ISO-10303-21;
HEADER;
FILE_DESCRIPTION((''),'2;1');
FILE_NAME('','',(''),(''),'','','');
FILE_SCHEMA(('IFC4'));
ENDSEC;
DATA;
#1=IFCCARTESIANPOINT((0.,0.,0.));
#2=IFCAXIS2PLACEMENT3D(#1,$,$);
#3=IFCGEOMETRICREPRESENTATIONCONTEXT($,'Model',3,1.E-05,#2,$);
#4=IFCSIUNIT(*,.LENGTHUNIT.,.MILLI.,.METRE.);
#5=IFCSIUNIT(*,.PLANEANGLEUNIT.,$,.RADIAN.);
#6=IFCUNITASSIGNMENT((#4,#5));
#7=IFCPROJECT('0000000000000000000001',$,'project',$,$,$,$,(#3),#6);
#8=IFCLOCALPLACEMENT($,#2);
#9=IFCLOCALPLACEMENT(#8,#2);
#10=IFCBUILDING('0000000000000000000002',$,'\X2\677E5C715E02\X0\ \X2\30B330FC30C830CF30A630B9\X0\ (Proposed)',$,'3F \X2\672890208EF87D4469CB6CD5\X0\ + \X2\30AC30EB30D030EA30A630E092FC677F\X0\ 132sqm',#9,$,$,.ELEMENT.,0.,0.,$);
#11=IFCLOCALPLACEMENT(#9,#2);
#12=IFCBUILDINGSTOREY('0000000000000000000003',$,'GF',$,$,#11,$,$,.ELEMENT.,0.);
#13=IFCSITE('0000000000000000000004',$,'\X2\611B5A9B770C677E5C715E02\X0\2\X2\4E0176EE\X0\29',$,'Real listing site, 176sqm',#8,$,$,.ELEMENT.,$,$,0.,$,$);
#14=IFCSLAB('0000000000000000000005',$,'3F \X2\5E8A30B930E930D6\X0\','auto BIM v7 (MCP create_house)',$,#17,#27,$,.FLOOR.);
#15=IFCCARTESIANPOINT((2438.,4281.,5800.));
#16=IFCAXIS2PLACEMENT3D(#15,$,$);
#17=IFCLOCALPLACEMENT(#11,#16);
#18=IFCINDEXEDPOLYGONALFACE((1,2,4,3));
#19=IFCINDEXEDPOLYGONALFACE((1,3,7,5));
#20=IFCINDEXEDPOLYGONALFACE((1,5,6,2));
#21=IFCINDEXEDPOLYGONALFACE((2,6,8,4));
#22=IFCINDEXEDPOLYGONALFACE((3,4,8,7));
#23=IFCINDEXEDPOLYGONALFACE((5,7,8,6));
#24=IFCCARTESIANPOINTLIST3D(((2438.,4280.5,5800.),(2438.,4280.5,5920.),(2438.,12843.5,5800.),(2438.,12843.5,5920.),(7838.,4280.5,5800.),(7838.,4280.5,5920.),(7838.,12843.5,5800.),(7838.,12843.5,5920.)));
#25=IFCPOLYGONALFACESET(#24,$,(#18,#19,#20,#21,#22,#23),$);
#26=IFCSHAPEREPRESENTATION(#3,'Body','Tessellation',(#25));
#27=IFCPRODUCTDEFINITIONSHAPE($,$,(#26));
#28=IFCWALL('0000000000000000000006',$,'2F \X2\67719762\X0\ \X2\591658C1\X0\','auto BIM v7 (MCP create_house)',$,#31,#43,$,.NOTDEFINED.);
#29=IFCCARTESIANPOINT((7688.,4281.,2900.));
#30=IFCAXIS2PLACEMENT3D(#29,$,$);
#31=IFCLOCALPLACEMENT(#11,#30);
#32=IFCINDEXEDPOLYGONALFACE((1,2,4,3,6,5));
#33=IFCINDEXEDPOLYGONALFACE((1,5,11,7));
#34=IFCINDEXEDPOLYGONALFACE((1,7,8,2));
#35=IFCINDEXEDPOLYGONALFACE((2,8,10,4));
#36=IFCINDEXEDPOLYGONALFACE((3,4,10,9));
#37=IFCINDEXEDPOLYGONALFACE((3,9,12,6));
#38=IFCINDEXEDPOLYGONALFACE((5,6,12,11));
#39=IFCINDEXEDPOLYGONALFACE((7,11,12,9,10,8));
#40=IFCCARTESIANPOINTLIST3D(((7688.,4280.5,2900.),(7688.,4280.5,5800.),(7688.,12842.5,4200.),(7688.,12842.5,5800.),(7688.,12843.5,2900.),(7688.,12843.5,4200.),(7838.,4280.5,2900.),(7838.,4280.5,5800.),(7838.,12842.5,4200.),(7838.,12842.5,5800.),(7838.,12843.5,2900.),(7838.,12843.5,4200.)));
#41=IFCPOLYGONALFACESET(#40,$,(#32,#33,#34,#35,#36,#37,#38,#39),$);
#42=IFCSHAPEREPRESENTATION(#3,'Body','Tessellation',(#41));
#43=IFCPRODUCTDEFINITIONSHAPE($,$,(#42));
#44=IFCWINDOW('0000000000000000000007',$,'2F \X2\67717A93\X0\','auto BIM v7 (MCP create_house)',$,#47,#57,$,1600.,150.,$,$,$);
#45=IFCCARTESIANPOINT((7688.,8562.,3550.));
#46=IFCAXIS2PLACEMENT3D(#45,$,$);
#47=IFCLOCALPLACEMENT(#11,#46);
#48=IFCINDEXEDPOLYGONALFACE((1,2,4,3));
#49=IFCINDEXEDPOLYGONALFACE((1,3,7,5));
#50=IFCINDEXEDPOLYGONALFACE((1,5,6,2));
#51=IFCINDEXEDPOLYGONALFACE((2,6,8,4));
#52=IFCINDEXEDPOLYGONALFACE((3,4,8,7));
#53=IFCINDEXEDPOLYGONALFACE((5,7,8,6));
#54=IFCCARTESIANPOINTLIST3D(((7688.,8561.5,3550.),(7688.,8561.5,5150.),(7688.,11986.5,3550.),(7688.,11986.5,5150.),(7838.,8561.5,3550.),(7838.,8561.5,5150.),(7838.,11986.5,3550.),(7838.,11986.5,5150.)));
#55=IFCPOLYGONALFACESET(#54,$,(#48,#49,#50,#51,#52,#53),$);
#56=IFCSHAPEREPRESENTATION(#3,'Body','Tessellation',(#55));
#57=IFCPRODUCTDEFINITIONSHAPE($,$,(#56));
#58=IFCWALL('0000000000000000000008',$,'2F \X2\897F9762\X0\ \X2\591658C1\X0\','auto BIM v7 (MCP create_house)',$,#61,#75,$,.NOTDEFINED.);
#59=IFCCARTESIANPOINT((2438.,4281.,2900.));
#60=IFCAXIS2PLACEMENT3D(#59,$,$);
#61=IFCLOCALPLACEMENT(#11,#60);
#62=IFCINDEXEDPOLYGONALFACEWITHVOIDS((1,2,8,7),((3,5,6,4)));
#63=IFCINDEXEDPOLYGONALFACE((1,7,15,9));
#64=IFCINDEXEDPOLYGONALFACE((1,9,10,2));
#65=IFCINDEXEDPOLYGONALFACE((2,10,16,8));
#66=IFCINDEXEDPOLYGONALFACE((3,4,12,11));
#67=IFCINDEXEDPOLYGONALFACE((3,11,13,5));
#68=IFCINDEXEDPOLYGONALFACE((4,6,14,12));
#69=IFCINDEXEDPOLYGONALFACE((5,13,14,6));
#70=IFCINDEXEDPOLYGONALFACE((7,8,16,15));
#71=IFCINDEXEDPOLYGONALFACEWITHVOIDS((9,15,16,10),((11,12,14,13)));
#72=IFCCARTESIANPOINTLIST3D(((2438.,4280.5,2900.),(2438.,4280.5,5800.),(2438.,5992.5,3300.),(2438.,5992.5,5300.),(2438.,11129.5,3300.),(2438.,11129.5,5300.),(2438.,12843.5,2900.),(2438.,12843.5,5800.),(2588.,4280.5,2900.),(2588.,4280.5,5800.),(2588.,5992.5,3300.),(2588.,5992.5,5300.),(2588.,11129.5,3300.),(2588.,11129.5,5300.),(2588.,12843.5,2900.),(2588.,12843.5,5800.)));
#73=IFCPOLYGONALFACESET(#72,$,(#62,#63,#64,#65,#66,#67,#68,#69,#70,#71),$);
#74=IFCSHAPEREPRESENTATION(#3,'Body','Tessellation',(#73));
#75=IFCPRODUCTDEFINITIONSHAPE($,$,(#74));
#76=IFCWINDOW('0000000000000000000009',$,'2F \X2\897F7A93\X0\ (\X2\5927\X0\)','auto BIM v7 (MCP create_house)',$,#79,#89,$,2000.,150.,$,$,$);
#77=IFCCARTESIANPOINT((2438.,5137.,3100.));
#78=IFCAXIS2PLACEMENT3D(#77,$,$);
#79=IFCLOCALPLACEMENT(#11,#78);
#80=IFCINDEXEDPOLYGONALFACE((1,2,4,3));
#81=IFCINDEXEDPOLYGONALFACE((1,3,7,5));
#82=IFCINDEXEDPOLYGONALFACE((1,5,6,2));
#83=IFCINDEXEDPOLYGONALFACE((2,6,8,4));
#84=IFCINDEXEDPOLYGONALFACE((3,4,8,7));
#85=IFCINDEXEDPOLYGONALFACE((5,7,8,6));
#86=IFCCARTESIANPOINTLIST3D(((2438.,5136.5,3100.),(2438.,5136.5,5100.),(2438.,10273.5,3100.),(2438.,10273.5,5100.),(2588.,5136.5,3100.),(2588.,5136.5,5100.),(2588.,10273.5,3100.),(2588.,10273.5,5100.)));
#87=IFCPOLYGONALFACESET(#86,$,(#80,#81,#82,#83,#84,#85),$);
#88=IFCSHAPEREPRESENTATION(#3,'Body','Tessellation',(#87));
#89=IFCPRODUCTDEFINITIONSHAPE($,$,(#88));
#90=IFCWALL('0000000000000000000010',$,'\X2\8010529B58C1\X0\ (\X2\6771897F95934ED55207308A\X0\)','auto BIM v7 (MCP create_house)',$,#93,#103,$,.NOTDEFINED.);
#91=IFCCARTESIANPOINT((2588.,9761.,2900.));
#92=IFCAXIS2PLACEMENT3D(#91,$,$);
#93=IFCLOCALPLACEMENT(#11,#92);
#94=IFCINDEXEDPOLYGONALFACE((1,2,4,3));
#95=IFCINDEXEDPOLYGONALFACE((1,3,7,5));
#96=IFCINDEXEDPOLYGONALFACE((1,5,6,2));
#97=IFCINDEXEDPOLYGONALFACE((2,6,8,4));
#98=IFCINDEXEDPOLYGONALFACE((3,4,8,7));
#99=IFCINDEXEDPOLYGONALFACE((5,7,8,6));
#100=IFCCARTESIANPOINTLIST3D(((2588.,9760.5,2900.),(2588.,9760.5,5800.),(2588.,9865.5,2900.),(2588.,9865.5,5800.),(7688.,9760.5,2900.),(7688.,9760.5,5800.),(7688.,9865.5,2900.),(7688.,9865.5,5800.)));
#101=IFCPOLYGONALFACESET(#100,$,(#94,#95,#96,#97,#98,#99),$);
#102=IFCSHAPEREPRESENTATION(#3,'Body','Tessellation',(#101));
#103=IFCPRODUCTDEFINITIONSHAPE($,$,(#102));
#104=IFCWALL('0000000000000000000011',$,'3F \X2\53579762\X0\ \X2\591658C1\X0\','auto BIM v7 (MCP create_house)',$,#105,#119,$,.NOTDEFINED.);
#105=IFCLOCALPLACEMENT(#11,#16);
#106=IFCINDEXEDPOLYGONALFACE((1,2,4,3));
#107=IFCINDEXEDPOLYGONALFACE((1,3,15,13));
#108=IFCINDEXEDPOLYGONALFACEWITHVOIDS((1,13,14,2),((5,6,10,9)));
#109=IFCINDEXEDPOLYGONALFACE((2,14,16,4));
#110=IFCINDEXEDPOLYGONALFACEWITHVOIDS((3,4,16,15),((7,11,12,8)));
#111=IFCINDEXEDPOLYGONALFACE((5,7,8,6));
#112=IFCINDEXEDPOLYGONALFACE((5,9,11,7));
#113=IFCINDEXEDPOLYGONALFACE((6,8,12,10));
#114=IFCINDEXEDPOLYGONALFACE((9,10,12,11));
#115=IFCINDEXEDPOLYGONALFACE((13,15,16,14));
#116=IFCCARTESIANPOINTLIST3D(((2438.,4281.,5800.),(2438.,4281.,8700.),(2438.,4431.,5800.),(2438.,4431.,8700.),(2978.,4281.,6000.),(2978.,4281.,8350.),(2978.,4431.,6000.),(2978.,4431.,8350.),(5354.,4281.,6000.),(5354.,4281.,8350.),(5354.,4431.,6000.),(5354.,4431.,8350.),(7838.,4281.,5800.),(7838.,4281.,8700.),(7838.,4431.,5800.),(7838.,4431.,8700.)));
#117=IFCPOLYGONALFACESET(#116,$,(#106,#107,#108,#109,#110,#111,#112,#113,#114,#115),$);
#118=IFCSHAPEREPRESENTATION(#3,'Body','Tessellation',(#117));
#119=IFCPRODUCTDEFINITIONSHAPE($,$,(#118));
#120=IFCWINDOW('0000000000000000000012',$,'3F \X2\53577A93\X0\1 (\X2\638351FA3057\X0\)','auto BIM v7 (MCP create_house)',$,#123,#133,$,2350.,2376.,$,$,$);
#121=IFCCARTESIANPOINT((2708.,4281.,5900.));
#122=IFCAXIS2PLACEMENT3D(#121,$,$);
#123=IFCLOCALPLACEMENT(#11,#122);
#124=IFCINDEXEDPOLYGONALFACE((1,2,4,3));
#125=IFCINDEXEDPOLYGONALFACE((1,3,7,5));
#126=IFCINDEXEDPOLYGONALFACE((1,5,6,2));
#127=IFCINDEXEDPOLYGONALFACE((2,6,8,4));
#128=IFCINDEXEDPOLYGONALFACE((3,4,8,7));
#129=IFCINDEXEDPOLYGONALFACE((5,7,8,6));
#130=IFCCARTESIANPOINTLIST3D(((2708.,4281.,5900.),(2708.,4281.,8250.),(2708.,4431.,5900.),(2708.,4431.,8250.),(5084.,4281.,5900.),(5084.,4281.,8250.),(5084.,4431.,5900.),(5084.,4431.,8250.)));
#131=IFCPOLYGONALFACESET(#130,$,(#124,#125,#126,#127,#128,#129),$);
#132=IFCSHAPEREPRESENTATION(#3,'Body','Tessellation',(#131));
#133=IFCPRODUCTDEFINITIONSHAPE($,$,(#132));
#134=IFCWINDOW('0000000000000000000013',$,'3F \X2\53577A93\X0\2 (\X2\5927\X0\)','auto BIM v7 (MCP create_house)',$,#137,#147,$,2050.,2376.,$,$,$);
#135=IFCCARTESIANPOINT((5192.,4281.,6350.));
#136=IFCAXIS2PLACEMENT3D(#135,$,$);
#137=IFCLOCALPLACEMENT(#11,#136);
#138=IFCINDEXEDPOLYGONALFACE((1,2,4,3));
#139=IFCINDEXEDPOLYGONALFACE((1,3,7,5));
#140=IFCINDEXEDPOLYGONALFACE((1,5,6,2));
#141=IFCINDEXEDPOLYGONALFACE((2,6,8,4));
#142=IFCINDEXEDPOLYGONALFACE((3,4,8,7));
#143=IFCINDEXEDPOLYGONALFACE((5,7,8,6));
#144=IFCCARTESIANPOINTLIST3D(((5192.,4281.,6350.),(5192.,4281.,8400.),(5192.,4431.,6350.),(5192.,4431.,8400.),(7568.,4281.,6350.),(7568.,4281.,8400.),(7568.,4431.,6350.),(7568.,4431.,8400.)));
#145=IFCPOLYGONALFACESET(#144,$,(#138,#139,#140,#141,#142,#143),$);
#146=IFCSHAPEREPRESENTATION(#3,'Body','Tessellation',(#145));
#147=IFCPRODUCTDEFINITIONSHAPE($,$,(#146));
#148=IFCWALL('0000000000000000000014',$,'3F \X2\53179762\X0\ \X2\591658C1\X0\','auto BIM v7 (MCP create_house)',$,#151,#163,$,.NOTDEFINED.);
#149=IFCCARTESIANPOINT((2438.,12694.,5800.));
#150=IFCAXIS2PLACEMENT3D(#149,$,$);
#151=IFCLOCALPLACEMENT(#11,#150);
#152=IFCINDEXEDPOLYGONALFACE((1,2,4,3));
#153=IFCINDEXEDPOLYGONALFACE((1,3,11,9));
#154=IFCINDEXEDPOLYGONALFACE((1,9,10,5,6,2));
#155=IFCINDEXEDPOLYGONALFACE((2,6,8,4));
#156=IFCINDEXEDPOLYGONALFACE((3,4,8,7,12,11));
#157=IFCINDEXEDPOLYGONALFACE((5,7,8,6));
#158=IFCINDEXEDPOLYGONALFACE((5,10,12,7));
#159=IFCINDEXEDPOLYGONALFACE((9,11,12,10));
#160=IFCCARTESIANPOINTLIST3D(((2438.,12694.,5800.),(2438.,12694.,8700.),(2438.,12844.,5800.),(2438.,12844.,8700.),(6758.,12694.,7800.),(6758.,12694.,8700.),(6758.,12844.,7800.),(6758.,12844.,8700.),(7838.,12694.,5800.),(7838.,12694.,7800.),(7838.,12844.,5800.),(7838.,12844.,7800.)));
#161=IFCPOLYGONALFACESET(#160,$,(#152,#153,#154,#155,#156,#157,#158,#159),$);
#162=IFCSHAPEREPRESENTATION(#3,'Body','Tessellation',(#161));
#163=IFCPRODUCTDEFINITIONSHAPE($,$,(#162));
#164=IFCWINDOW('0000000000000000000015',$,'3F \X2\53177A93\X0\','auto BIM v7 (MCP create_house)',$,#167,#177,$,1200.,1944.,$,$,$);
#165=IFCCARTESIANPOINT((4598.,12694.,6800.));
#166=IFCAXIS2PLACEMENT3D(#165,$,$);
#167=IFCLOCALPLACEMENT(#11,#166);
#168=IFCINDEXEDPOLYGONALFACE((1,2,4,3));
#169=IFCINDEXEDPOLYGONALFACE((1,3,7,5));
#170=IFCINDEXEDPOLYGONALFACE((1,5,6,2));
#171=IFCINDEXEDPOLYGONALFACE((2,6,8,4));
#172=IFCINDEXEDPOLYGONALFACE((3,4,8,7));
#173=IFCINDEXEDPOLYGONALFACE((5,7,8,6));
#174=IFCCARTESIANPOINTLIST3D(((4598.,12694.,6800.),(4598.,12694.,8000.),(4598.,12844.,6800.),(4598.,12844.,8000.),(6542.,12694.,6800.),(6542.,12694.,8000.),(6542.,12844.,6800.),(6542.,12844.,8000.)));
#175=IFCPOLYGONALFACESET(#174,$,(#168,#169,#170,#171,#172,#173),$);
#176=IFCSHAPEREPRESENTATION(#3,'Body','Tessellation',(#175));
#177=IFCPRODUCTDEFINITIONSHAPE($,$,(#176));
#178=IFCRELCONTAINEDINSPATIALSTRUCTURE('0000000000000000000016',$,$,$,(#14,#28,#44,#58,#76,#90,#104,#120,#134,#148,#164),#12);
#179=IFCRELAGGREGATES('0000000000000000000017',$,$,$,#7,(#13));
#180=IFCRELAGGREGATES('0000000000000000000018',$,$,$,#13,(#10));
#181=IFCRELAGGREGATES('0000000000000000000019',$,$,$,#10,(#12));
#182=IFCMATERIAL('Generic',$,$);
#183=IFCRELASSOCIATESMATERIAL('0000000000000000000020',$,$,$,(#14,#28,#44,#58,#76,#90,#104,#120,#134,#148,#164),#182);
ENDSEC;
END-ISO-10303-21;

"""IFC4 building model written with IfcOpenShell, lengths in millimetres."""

from ifc_helpers import new_model, si_unit, frame, frame_2d, origin, place, context, project, spatial, rectangle, extrude, material, element, fill, save


model = new_model("IFC4")

# Units and contexts
model_context = context("Model", 3, precision=1e-05, world=origin())
ifc_project = project(units=[si_unit("LENGTHUNIT", "METRE", prefix="MILLI"), si_unit("PLANEANGLEUNIT", "RADIAN")], contexts=[model_context])

# Site, building, storey
site_placement = place(None, origin())
site = spatial("IfcSite", under=ifc_project, at=site_placement, Name="愛媛県松山市2丁目29", ObjectType="Real listing site, 176sqm", CompositionType="ELEMENT", RefElevation=0.0)
building_placement = place(site_placement, origin())
building = spatial("IfcBuilding", under=site, at=building_placement, Name="松山市 コートハウス (Proposed)", ObjectType="3F 木造軸組構法 + ガルバリウム鋼板 132sqm", CompositionType="ELEMENT", ElevationOfRefHeight=0.0, ElevationOfTerrain=0.0)
storey_placement = place(building_placement, origin())
storey = spatial("IfcBuildingStorey", under=building, at=storey_placement, Name="GF", CompositionType="ELEMENT", Elevation=0.0)

# Slab
ifc_material = material(Name="Generic")
slab_placement = place(storey_placement, frame((2438.0, 4281.0, 5800.0)))
element("IfcSlab", 1, at=slab_placement, inside=storey, material=ifc_material, Name="3F 床スラブ", Description="auto BIM v7 (MCP create_house)", PredefinedType="FLOOR", context=model_context, shape_type="SweptSolid", body=[
    extrude(rectangle(XDim=5400.0, YDim=8563.0, at=frame_2d((2700.0, 4281.0))), frame((2438.0, 4281.0, 5800.0)), (0.0, 0.0, 1.0), 120.0),
])

# Walls, openings, windows
wall_1_placement = place(storey_placement, frame((7688.0, 4281.0, 2900.0)))
wall_1 = element("IfcWall", 2, at=wall_1_placement, inside=storey, material=ifc_material, Name="2F 東面 外壁", Description="auto BIM v7 (MCP create_house)", PredefinedType="NOTDEFINED", context=model_context, shape_type="SweptSolid", body=[
    extrude(rectangle(XDim=150.0, YDim=8563.0, at=frame_2d((75.0, 4281.0))), frame((7688.0, 4281.0, 2900.0)), (0.0, 0.0, 1.0), 2900.0),
])
opening_1_placement = place(storey_placement, frame((7688.0, 8562.0, 3550.0)))
opening_1 = element("IfcOpeningElement", 3, at=opening_1_placement, cuts=wall_1, PredefinedType="NOTDEFINED", context=model_context, shape_type="SweptSolid", body=[
    extrude(rectangle(XDim=150.0, YDim=3425.0, at=frame_2d((75.0, 1712.0))), frame((7688.0, 8562.0, 3550.0)), (0.0, 0.0, 1.0), 1600.0),
])
window_1_placement = place(storey_placement, frame((7688.0, 8562.0, 3550.0)))
window_1 = element("IfcWindow", 4, at=window_1_placement, inside=storey, material=ifc_material, Name="2F 東窓", Description="auto BIM v7 (MCP create_house)", OverallHeight=1600.0, OverallWidth=150.0, context=model_context, shape_type="SweptSolid", body=[
    extrude(rectangle(XDim=150.0, YDim=3425.0, at=frame_2d((75.0, 1712.0))), frame((7688.0, 8562.0, 3550.0)), (0.0, 0.0, 1.0), 1600.0),
])
fill(opening_1, window_1)
wall_2_placement = place(storey_placement, frame((2438.0, 4281.0, 2900.0)))
wall_2 = element("IfcWall", 5, at=wall_2_placement, inside=storey, material=ifc_material, Name="2F 西面 外壁", Description="auto BIM v7 (MCP create_house)", PredefinedType="NOTDEFINED", context=model_context, shape_type="SweptSolid", body=[
    extrude(rectangle(XDim=150.0, YDim=8563.0, at=frame_2d((75.0, 4281.0))), frame((2438.0, 4281.0, 2900.0)), (0.0, 0.0, 1.0), 2900.0),
])
opening_2_placement = place(storey_placement, frame((2438.0, 5137.0, 3100.0)))
opening_2 = element("IfcOpeningElement", 6, at=opening_2_placement, cuts=wall_2, PredefinedType="NOTDEFINED", context=model_context, shape_type="SweptSolid", body=[
    extrude(rectangle(XDim=150.0, YDim=5137.0, at=frame_2d((75.0, 2568.0))), frame((2438.0, 5137.0, 3100.0)), (0.0, 0.0, 1.0), 2000.0),
])
window_2_placement = place(storey_placement, frame((2438.0, 5137.0, 3100.0)))
window_2 = element("IfcWindow", 7, at=window_2_placement, inside=storey, material=ifc_material, Name="2F 西窓 (大)", Description="auto BIM v7 (MCP create_house)", OverallHeight=2000.0, OverallWidth=150.0, context=model_context, shape_type="SweptSolid", body=[
    extrude(rectangle(XDim=150.0, YDim=5137.0, at=frame_2d((75.0, 2568.0))), frame((2438.0, 5137.0, 3100.0)), (0.0, 0.0, 1.0), 2000.0),
])
fill(opening_2, window_2)

# Wall
wall_3_placement = place(storey_placement, frame((2588.0, 9761.0, 2900.0)))
element("IfcWall", 8, at=wall_3_placement, inside=storey, material=ifc_material, Name="耐力壁 (東西間仕切り)", Description="auto BIM v7 (MCP create_house)", PredefinedType="NOTDEFINED", context=model_context, shape_type="SweptSolid", body=[
    extrude(rectangle(XDim=5100.0, YDim=105.0, at=frame_2d((2550.0, 52.0))), frame((2588.0, 9761.0, 2900.0)), (0.0, 0.0, 1.0), 2900.0),
])

# Wall, openings, windows
wall_4_placement = place(storey_placement, frame((2438.0, 4281.0, 5800.0)))
wall_4 = element("IfcWall", 9, at=wall_4_placement, inside=storey, material=ifc_material, Name="3F 南面 外壁", Description="auto BIM v7 (MCP create_house)", PredefinedType="NOTDEFINED", context=model_context, shape_type="SweptSolid", body=[
    extrude(rectangle(XDim=5400.0, YDim=150.0, at=frame_2d((2700.0, 75.0))), frame((2438.0, 4281.0, 5800.0)), (0.0, 0.0, 1.0), 2900.0),
])
opening_3_placement = place(storey_placement, frame((2708.0, 4281.0, 5900.0)))
opening_3 = element("IfcOpeningElement", 10, at=opening_3_placement, cuts=wall_4, PredefinedType="NOTDEFINED", context=model_context, shape_type="SweptSolid", body=[
    extrude(rectangle(XDim=2376.0, YDim=150.0, at=frame_2d((1188.0, 75.0))), frame((2708.0, 4281.0, 5900.0)), (0.0, 0.0, 1.0), 2350.0),
])
opening_4_placement = place(storey_placement, frame((5192.0, 4281.0, 6350.0)))
opening_4 = element("IfcOpeningElement", 11, at=opening_4_placement, cuts=wall_4, PredefinedType="NOTDEFINED", context=model_context, shape_type="SweptSolid", body=[
    extrude(rectangle(XDim=2376.0, YDim=150.0, at=frame_2d((1188.0, 75.0))), frame((5192.0, 4281.0, 6350.0)), (0.0, 0.0, 1.0), 2050.0),
])
window_3_placement = place(storey_placement, frame((2708.0, 4281.0, 5900.0)))
window_3 = element("IfcWindow", 12, at=window_3_placement, inside=storey, material=ifc_material, Name="3F 南窓1 (掃出し)", Description="auto BIM v7 (MCP create_house)", OverallHeight=2350.0, OverallWidth=2376.0, context=model_context, shape_type="SweptSolid", body=[
    extrude(rectangle(XDim=2376.0, YDim=150.0, at=frame_2d((1188.0, 75.0))), frame((2708.0, 4281.0, 5900.0)), (0.0, 0.0, 1.0), 2350.0),
])
fill(opening_3, window_3)
window_4_placement = place(storey_placement, frame((5192.0, 4281.0, 6350.0)))
window_4 = element("IfcWindow", 13, at=window_4_placement, inside=storey, material=ifc_material, Name="3F 南窓2 (大)", Description="auto BIM v7 (MCP create_house)", OverallHeight=2050.0, OverallWidth=2376.0, context=model_context, shape_type="SweptSolid", body=[
    extrude(rectangle(XDim=2376.0, YDim=150.0, at=frame_2d((1188.0, 75.0))), frame((5192.0, 4281.0, 6350.0)), (0.0, 0.0, 1.0), 2050.0),
])
fill(opening_4, window_4)

# Wall, opening, window
wall_5_placement = place(storey_placement, frame((2438.0, 12694.0, 5800.0)))
wall_5 = element("IfcWall", 14, at=wall_5_placement, inside=storey, material=ifc_material, Name="3F 北面 外壁", Description="auto BIM v7 (MCP create_house)", PredefinedType="NOTDEFINED", context=model_context, shape_type="SweptSolid", body=[
    extrude(rectangle(XDim=5400.0, YDim=150.0, at=frame_2d((2700.0, 75.0))), frame((2438.0, 12694.0, 5800.0)), (0.0, 0.0, 1.0), 2900.0),
])
opening_5_placement = place(storey_placement, frame((4598.0, 12694.0, 6800.0)))
opening_5 = element("IfcOpeningElement", 15, at=opening_5_placement, cuts=wall_5, PredefinedType="NOTDEFINED", context=model_context, shape_type="SweptSolid", body=[
    extrude(rectangle(XDim=1944.0, YDim=150.0, at=frame_2d((972.0, 75.0))), frame((4598.0, 12694.0, 6800.0)), (0.0, 0.0, 1.0), 1200.0),
])
window_5_placement = place(storey_placement, frame((4598.0, 12694.0, 6800.0)))
window_5 = element("IfcWindow", 16, at=window_5_placement, inside=storey, material=ifc_material, Name="3F 北窓", Description="auto BIM v7 (MCP create_house)", OverallHeight=1200.0, OverallWidth=1944.0, context=model_context, shape_type="SweptSolid", body=[
    extrude(rectangle(XDim=1944.0, YDim=150.0, at=frame_2d((972.0, 75.0))), frame((4598.0, 12694.0, 6800.0)), (0.0, 0.0, 1.0), 1200.0),
])
fill(opening_5, window_5)

save(model, "model.ifc")
